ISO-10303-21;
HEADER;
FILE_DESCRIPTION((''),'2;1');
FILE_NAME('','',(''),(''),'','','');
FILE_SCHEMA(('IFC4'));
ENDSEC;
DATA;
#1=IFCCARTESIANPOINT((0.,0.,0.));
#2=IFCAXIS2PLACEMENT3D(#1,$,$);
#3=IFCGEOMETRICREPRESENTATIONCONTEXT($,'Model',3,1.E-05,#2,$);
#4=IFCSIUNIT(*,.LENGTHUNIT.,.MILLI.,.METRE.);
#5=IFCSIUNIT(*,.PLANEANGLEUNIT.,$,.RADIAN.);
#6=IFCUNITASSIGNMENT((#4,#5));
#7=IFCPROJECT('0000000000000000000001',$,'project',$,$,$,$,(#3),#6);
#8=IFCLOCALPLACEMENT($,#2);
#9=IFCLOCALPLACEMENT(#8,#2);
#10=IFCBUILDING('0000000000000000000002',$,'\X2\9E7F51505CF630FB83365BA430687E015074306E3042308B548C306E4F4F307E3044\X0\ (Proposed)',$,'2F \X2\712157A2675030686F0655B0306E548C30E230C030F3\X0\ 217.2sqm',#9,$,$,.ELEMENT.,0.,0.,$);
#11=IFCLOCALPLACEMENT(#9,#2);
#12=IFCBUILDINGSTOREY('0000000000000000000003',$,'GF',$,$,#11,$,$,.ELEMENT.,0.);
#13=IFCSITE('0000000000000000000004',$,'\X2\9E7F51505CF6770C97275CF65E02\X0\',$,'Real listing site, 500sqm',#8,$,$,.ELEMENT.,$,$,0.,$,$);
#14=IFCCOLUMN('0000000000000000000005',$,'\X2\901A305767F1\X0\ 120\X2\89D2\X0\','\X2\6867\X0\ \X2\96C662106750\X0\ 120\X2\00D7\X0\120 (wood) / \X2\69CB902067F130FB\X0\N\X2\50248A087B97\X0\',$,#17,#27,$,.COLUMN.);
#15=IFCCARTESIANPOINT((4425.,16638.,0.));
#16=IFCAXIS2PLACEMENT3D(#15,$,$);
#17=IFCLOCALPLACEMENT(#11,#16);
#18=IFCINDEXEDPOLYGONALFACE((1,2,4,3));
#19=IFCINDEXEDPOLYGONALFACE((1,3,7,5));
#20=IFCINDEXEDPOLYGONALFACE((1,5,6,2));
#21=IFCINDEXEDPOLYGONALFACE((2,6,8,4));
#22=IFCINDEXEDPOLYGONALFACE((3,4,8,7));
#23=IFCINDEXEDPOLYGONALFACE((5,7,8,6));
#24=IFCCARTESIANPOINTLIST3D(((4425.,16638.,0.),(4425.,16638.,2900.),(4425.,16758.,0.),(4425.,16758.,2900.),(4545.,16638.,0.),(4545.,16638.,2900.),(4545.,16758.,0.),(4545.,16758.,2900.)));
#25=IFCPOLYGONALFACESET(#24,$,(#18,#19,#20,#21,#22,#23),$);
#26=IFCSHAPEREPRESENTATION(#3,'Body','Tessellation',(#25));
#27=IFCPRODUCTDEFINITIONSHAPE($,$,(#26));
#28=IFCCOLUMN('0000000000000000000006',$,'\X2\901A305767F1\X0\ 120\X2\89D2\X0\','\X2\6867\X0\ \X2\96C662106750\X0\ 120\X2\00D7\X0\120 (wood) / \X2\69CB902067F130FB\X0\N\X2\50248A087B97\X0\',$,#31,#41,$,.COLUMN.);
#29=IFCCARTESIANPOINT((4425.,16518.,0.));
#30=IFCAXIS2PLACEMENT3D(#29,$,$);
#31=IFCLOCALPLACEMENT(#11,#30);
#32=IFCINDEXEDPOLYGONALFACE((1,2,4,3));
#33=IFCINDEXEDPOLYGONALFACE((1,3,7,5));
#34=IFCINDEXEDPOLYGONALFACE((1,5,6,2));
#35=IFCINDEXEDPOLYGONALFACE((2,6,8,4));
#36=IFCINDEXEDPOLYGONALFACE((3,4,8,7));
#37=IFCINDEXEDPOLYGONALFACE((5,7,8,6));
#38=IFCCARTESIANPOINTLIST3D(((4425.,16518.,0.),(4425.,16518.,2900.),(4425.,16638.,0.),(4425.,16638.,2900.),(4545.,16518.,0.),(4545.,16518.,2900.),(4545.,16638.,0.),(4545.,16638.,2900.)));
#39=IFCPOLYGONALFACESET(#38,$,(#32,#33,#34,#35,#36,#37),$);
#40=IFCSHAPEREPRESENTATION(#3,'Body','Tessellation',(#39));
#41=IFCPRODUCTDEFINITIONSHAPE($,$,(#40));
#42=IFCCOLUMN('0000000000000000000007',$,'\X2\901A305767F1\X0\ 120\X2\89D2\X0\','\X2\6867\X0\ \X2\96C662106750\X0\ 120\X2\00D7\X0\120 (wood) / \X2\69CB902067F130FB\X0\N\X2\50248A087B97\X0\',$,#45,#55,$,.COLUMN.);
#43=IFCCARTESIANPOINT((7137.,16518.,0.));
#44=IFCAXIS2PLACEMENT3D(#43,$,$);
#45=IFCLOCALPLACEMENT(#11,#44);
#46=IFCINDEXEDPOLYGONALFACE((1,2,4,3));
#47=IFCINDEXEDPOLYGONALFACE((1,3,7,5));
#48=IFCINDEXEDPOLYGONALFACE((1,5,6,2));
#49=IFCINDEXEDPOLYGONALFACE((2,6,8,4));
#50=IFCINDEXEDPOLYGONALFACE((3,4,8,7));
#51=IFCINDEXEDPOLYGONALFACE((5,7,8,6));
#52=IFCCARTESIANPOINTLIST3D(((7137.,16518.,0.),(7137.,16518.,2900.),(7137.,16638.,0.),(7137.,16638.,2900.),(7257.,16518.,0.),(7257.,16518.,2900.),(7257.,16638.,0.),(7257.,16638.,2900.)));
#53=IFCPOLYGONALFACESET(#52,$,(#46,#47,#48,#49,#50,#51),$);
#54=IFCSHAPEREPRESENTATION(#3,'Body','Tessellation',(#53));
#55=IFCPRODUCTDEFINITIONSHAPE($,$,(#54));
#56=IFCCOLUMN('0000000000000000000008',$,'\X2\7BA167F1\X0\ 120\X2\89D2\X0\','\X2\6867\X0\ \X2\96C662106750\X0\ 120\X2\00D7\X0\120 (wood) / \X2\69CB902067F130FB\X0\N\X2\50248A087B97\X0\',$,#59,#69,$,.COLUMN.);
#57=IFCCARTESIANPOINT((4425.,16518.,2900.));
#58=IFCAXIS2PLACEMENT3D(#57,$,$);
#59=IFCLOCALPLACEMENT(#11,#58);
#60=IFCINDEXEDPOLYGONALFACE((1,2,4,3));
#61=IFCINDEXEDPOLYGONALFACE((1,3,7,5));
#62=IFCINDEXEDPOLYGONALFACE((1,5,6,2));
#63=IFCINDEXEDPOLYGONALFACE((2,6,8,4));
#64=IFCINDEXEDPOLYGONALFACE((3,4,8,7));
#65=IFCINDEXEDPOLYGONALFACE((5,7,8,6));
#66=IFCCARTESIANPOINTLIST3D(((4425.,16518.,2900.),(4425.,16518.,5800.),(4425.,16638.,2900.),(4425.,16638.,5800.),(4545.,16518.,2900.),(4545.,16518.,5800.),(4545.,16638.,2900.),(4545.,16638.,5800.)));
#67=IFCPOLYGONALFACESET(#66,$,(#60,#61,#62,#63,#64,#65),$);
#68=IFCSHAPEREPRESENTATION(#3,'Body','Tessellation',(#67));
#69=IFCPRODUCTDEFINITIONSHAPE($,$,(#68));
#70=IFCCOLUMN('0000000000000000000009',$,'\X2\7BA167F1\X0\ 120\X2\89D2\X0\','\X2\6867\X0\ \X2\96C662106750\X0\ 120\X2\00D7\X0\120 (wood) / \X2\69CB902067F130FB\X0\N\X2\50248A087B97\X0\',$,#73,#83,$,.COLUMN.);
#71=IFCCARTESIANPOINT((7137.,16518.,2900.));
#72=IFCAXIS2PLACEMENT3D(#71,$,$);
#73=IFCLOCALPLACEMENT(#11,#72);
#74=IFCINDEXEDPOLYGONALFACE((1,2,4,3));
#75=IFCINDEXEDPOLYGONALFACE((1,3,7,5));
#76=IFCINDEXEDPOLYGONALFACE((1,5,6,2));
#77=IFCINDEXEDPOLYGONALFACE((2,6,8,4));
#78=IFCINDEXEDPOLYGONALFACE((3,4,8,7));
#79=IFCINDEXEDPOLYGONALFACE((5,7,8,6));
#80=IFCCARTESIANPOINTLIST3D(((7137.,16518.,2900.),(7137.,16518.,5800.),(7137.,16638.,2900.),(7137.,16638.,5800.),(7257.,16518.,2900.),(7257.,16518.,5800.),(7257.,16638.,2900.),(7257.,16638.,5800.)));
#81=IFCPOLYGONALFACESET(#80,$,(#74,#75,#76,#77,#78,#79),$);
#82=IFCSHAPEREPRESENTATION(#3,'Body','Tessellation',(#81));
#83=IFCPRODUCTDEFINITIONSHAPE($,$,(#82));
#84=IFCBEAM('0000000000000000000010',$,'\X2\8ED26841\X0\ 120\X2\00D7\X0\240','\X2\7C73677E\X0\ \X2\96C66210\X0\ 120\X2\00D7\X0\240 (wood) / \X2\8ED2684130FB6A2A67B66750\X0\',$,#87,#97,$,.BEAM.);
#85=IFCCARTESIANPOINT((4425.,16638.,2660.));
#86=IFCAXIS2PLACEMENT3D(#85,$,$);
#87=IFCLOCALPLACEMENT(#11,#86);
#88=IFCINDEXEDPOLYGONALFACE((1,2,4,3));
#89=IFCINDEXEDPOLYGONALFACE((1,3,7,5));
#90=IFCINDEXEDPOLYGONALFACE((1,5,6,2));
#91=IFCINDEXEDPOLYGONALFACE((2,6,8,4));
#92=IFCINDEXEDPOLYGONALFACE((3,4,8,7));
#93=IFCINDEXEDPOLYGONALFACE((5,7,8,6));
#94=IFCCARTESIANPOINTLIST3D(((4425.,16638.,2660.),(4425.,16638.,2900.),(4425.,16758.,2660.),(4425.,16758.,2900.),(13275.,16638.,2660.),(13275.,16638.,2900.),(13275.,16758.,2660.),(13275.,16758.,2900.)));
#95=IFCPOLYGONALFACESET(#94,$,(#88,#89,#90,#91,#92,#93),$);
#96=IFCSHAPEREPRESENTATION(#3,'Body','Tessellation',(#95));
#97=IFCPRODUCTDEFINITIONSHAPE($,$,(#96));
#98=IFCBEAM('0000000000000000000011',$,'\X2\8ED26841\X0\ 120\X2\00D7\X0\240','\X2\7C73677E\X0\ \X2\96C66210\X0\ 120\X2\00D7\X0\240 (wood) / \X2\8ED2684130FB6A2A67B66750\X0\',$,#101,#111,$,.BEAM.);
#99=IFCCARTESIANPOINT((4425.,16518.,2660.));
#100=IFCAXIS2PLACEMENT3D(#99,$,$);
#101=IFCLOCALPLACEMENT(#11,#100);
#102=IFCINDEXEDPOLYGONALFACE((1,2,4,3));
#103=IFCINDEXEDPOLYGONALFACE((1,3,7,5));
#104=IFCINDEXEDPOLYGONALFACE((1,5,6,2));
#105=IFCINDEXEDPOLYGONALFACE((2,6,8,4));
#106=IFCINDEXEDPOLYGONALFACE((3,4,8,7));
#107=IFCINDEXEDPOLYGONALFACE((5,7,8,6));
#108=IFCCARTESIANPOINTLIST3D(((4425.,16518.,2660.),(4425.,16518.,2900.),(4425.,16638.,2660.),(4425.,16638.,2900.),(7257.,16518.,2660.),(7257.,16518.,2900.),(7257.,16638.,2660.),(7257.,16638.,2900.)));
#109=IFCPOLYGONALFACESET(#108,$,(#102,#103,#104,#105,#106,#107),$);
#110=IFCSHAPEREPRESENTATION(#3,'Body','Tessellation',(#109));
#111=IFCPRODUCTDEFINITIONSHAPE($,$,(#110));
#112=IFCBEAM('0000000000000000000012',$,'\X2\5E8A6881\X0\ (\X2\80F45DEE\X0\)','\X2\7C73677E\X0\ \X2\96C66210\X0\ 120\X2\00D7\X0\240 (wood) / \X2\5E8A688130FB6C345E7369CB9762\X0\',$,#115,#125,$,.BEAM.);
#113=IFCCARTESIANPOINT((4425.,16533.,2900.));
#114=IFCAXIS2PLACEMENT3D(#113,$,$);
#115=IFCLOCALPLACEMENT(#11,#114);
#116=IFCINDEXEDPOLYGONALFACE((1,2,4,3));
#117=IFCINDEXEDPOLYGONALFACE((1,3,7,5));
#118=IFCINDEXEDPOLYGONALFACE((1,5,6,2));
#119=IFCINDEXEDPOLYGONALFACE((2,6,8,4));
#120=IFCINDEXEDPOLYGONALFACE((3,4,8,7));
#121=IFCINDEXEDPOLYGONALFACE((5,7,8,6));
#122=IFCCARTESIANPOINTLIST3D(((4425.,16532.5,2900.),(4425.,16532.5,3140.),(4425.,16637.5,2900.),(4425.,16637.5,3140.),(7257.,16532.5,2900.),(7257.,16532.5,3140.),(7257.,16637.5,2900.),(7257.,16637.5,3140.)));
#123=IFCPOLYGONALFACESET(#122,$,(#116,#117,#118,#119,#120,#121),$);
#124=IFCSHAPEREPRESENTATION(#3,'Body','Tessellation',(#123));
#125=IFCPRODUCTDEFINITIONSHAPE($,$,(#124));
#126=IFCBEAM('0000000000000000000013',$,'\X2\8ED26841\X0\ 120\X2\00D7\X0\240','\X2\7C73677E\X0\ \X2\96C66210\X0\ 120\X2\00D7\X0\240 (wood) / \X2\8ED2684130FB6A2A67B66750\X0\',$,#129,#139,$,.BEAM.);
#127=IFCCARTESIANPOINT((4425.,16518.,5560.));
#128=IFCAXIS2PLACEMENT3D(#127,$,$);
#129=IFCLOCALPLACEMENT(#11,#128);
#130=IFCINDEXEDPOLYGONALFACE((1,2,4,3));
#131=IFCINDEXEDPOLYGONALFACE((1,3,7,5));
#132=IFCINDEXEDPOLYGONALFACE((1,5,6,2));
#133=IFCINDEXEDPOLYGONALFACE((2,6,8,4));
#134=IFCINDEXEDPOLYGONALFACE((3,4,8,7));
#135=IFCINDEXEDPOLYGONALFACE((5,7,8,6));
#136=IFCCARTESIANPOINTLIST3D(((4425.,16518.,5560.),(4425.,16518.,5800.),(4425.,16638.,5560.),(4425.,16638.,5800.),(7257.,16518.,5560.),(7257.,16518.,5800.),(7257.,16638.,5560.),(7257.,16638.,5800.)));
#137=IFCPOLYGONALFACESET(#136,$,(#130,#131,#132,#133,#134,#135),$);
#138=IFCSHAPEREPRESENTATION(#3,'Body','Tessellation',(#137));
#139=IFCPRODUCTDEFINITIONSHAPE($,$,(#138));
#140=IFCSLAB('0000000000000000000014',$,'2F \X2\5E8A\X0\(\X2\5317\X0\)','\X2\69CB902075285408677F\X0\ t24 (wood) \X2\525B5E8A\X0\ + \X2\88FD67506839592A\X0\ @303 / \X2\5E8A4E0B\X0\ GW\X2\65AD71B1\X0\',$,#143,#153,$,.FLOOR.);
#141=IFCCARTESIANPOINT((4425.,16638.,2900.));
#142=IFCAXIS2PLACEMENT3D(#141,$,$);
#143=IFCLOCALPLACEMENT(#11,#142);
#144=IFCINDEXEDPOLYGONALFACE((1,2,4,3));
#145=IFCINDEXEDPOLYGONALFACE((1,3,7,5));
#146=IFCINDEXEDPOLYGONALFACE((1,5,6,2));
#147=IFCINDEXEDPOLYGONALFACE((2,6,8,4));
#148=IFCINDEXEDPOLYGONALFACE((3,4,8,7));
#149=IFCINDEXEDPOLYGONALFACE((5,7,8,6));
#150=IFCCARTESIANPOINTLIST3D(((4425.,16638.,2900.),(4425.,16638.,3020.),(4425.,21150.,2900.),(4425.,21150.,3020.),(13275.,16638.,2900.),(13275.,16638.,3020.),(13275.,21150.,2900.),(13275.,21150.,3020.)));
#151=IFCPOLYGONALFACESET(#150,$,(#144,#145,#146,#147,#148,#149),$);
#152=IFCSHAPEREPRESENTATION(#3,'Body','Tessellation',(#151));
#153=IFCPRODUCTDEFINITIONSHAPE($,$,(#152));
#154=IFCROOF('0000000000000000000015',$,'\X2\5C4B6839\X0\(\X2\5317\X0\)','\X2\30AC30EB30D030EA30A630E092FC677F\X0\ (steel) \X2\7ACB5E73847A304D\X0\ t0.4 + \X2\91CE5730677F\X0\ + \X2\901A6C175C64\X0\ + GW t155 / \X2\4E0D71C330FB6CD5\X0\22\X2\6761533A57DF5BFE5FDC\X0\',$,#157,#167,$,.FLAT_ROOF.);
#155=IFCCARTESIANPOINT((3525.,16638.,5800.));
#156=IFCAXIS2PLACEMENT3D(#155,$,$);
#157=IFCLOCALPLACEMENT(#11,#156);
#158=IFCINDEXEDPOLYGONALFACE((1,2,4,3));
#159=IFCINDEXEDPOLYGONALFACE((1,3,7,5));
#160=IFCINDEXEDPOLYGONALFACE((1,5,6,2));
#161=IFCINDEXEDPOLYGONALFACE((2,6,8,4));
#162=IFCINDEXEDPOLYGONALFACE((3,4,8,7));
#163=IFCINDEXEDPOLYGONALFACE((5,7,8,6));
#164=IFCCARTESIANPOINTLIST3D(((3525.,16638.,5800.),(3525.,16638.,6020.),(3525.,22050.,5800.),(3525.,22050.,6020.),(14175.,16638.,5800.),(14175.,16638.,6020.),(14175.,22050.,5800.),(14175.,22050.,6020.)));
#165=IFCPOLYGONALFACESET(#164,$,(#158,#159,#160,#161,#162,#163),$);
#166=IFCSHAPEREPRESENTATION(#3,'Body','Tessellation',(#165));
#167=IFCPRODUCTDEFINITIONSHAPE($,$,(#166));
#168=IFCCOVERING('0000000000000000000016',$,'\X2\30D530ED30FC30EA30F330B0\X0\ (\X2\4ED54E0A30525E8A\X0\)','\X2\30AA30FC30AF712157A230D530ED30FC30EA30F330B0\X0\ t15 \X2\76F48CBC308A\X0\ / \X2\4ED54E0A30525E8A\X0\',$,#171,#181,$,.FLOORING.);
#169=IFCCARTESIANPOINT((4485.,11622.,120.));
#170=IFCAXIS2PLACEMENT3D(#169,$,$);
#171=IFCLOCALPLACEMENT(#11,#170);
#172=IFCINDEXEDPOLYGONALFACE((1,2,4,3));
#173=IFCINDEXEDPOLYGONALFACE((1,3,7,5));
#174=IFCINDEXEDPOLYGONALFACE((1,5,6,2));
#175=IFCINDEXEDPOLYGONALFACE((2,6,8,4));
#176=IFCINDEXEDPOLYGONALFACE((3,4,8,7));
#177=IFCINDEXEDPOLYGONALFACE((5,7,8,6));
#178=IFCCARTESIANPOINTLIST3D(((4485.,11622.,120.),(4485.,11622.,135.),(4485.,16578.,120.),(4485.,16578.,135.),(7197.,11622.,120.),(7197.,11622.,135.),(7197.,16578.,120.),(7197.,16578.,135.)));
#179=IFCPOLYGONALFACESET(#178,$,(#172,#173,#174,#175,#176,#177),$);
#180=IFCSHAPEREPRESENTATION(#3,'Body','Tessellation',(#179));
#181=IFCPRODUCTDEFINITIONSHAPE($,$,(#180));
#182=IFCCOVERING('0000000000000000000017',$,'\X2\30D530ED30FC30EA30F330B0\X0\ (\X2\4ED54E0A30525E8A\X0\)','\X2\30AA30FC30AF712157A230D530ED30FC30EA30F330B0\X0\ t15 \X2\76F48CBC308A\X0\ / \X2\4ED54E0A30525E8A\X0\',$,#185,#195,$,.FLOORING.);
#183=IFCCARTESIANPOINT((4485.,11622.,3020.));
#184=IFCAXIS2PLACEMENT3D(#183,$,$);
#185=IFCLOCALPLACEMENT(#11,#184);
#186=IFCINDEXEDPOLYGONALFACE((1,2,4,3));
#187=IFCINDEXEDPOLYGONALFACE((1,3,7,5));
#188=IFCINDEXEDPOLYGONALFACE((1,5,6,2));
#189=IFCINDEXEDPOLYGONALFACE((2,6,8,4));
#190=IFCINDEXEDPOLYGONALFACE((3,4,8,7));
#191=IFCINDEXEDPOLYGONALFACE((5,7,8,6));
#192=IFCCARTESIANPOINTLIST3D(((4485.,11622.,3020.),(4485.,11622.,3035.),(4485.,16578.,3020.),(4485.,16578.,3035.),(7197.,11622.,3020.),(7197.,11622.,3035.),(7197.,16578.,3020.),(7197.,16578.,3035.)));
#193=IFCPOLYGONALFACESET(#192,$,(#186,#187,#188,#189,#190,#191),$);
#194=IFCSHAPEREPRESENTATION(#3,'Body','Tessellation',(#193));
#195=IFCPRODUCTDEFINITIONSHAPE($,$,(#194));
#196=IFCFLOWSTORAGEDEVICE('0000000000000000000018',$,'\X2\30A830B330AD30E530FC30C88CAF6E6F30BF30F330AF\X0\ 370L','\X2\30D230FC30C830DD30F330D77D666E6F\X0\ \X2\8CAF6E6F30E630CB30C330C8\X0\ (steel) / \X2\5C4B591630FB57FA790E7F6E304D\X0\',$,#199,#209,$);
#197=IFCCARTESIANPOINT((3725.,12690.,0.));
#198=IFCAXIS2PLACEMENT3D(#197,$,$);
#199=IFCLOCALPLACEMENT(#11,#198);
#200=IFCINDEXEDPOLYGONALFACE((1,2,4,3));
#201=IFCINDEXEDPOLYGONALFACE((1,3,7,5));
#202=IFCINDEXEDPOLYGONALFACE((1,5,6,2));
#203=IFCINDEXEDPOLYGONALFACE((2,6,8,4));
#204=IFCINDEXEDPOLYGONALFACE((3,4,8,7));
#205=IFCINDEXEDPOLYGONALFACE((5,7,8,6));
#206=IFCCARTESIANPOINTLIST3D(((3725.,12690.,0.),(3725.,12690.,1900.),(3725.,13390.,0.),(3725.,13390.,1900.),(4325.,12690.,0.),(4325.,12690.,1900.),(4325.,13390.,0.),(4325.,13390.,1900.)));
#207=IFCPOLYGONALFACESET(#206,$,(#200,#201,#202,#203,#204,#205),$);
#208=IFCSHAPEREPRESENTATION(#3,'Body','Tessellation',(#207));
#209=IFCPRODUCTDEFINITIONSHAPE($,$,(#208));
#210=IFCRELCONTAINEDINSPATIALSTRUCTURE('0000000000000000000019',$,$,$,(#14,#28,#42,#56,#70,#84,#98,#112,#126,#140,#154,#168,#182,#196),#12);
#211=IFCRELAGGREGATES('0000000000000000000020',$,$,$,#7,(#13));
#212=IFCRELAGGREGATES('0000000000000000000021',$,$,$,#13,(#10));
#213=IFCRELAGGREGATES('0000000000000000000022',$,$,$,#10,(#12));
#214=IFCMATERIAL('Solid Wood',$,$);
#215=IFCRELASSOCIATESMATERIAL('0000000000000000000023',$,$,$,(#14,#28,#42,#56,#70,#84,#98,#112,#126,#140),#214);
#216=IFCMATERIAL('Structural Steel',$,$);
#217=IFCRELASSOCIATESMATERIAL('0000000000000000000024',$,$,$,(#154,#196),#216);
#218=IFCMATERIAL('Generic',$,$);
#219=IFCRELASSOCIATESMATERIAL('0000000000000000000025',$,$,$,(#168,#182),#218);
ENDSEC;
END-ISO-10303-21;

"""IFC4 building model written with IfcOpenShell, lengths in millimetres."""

from ifc_helpers import new_model, si_unit, frame, frame_2d, origin, place, context, project, spatial, rectangle, extrude, material, element, save


model = new_model("IFC4")

# Units and contexts
model_context = context("Model", 3, precision=1e-05, world=origin())
ifc_project = project(units=[si_unit("LENGTHUNIT", "METRE", prefix="MILLI"), si_unit("PLANEANGLEUNIT", "RADIAN")], contexts=[model_context])

# Site, building, storey
site_placement = place(None, origin())
site = spatial("IfcSite", under=ifc_project, at=site_placement, Name="鹿児島県霧島市", ObjectType="Real listing site, 500sqm", CompositionType="ELEMENT", RefElevation=0.0)
building_placement = place(site_placement, origin())
building = spatial("IfcBuilding", under=site, at=building_placement, Name="鹿児島・茶室と縁側のある和の住まい (Proposed)", ObjectType="2F 無垢材と漆喰の和モダン 217.2sqm", CompositionType="ELEMENT", ElevationOfRefHeight=0.0, ElevationOfTerrain=0.0)
storey_placement = place(building_placement, origin())
storey = spatial("IfcBuildingStorey", under=building, at=storey_placement, Name="GF", CompositionType="ELEMENT", Elevation=0.0)

# Columns
ifc_material_1 = material(Name="Solid Wood")
column_1_placement = place(storey_placement, frame((4425.0, 16638.0, 0.0)))
element("IfcColumn", 1, at=column_1_placement, inside=storey, material=ifc_material_1, Name="通し柱 120角", Description="桧 集成材 120×120 (wood) / 構造柱・N値計算", PredefinedType="COLUMN", context=model_context, shape_type="SweptSolid", body=[
    extrude(rectangle(XDim=120.0, YDim=120.0, at=frame_2d((60.0, 60.0))), frame((4425.0, 16638.0, 0.0)), (0.0, 0.0, 1.0), 2900.0),
])
column_2_placement = place(storey_placement, frame((4425.0, 16518.0, 0.0)))
element("IfcColumn", 2, at=column_2_placement, inside=storey, material=ifc_material_1, Name="通し柱 120角", Description="桧 集成材 120×120 (wood) / 構造柱・N値計算", PredefinedType="COLUMN", context=model_context, shape_type="SweptSolid", body=[
    extrude(rectangle(XDim=120.0, YDim=120.0, at=frame_2d((60.0, 60.0))), frame((4425.0, 16518.0, 0.0)), (0.0, 0.0, 1.0), 2900.0),
])
column_3_placement = place(storey_placement, frame((7137.0, 16518.0, 0.0)))
element("IfcColumn", 3, at=column_3_placement, inside=storey, material=ifc_material_1, Name="通し柱 120角", Description="桧 集成材 120×120 (wood) / 構造柱・N値計算", PredefinedType="COLUMN", context=model_context, shape_type="SweptSolid", body=[
    extrude(rectangle(XDim=120.0, YDim=120.0, at=frame_2d((60.0, 60.0))), frame((7137.0, 16518.0, 0.0)), (0.0, 0.0, 1.0), 2900.0),
])
column_4_placement = place(storey_placement, frame((4425.0, 16518.0, 2900.0)))
element("IfcColumn", 4, at=column_4_placement, inside=storey, material=ifc_material_1, Name="管柱 120角", Description="桧 集成材 120×120 (wood) / 構造柱・N値計算", PredefinedType="COLUMN", context=model_context, shape_type="SweptSolid", body=[
    extrude(rectangle(XDim=120.0, YDim=120.0, at=frame_2d((60.0, 60.0))), frame((4425.0, 16518.0, 2900.0)), (0.0, 0.0, 1.0), 2900.0),
])
column_5_placement = place(storey_placement, frame((7137.0, 16518.0, 2900.0)))
element("IfcColumn", 5, at=column_5_placement, inside=storey, material=ifc_material_1, Name="管柱 120角", Description="桧 集成材 120×120 (wood) / 構造柱・N値計算", PredefinedType="COLUMN", context=model_context, shape_type="SweptSolid", body=[
    extrude(rectangle(XDim=120.0, YDim=120.0, at=frame_2d((60.0, 60.0))), frame((7137.0, 16518.0, 2900.0)), (0.0, 0.0, 1.0), 2900.0),
])

# Beams
beam_1_placement = place(storey_placement, frame((4425.0, 16638.0, 2660.0)))
element("IfcBeam", 6, at=beam_1_placement, inside=storey, material=ifc_material_1, Name="軒桁 120×240", Description="米松 集成 120×240 (wood) / 軒桁・横架材", PredefinedType="BEAM", context=model_context, shape_type="SweptSolid", body=[
    extrude(rectangle(XDim=8850.0, YDim=120.0, at=frame_2d((4425.0, 60.0))), frame((4425.0, 16638.0, 2660.0)), (0.0, 0.0, 1.0), 240.0),
])
beam_2_placement = place(storey_placement, frame((4425.0, 16518.0, 2660.0)))
element("IfcBeam", 7, at=beam_2_placement, inside=storey, material=ifc_material_1, Name="軒桁 120×240", Description="米松 集成 120×240 (wood) / 軒桁・横架材", PredefinedType="BEAM", context=model_context, shape_type="SweptSolid", body=[
    extrude(rectangle(XDim=2832.0, YDim=120.0, at=frame_2d((1416.0, 60.0))), frame((4425.0, 16518.0, 2660.0)), (0.0, 0.0, 1.0), 240.0),
])
beam_3_placement = place(storey_placement, frame((4425.0, 16533.0, 2900.0)))
element("IfcBeam", 8, at=beam_3_placement, inside=storey, material=ifc_material_1, Name="床梁 (胴差)", Description="米松 集成 120×240 (wood) / 床梁・水平構面", PredefinedType="BEAM", context=model_context, shape_type="SweptSolid", body=[
    extrude(rectangle(XDim=2832.0, YDim=105.0, at=frame_2d((1416.0, 52.0))), frame((4425.0, 16533.0, 2900.0)), (0.0, 0.0, 1.0), 240.0),
])
beam_4_placement = place(storey_placement, frame((4425.0, 16518.0, 5560.0)))
element("IfcBeam", 9, at=beam_4_placement, inside=storey, material=ifc_material_1, Name="軒桁 120×240", Description="米松 集成 120×240 (wood) / 軒桁・横架材", PredefinedType="BEAM", context=model_context, shape_type="SweptSolid", body=[
    extrude(rectangle(XDim=2832.0, YDim=120.0, at=frame_2d((1416.0, 60.0))), frame((4425.0, 16518.0, 5560.0)), (0.0, 0.0, 1.0), 240.0),
])

# Slab
slab_1_placement = place(storey_placement, frame((4425.0, 16638.0, 2900.0)))
element("IfcSlab", 10, at=slab_1_placement, inside=storey, material=ifc_material_1, Name="2F 床(北)", Description="構造用合板 t24 (wood) 剛床 + 製材根太 @303 / 床下 GW断熱", PredefinedType="FLOOR", context=model_context, shape_type="SweptSolid", body=[
    extrude(rectangle(XDim=8850.0, YDim=4512.0, at=frame_2d((4425.0, 2256.0))), frame((4425.0, 16638.0, 2900.0)), (0.0, 0.0, 1.0), 120.0),
])

# Roof
ifc_material_2 = material(Name="Structural Steel")
for number, where, name in (
    (11, (3525.0, 16638.0, 5800.0), "屋根(北)"),
):
    element("IfcRoof", number, at=place(storey_placement, frame(where)), inside=storey, material=ifc_material_2, Name=name, Description="ガルバリウム鋼板 (steel) 立平葺き t0.4 + 野地板 + 通気層 + GW t155 / 不燃・法22条区域対応", PredefinedType="FLAT_ROOF", context=model_context, shape_type="SweptSolid", body=[
        extrude(rectangle(XDim=10650.0, YDim=5412.0, at=frame_2d((5325.0, 2706.0))), frame((3525.0, 16638.0, 5800.0)), (0.0, 0.0, 1.0), 220.0),
    ])

# Coverings
ifc_material_3 = material(Name="Generic")
covering_1_placement = place(storey_placement, frame((4485.0, 11622.0, 120.0)))
element("IfcCovering", 12, at=covering_1_placement, inside=storey, material=ifc_material_3, Name="フローリング (仕上げ床)", Description="オーク無垢フローリング t15 直貼り / 仕上げ床", PredefinedType="FLOORING", context=model_context, shape_type="SweptSolid", body=[
    extrude(rectangle(XDim=2712.0, YDim=4956.0, at=frame_2d((1356.0, 2478.0))), frame((4485.0, 11622.0, 120.0)), (0.0, 0.0, 1.0), 15.0),
])
covering_2_placement = place(storey_placement, frame((4485.0, 11622.0, 3020.0)))
element("IfcCovering", 13, at=covering_2_placement, inside=storey, material=ifc_material_3, Name="フローリング (仕上げ床)", Description="オーク無垢フローリング t15 直貼り / 仕上げ床", PredefinedType="FLOORING", context=model_context, shape_type="SweptSolid", body=[
    extrude(rectangle(XDim=2712.0, YDim=4956.0, at=frame_2d((1356.0, 2478.0))), frame((4485.0, 11622.0, 3020.0)), (0.0, 0.0, 1.0), 15.0),
])

# Flow storage device
flow_storage_device_placement = place(storey_placement, frame((3725.0, 12690.0, 0.0)))
element("IfcFlowStorageDevice", 14, at=flow_storage_device_placement, inside=storey, material=ifc_material_2, Name="エコキュート貯湯タンク 370L", Description="ヒートポンプ給湯 貯湯ユニット (steel) / 屋外・基礎置き", context=model_context, shape_type="SweptSolid", body=[
    extrude(rectangle(XDim=600.0, YDim=700.0, at=frame_2d((300.0, 350.0))), frame((3725.0, 12690.0, 0.0)), (0.0, 0.0, 1.0), 1900.0),
])

save(model, "model.ifc")
